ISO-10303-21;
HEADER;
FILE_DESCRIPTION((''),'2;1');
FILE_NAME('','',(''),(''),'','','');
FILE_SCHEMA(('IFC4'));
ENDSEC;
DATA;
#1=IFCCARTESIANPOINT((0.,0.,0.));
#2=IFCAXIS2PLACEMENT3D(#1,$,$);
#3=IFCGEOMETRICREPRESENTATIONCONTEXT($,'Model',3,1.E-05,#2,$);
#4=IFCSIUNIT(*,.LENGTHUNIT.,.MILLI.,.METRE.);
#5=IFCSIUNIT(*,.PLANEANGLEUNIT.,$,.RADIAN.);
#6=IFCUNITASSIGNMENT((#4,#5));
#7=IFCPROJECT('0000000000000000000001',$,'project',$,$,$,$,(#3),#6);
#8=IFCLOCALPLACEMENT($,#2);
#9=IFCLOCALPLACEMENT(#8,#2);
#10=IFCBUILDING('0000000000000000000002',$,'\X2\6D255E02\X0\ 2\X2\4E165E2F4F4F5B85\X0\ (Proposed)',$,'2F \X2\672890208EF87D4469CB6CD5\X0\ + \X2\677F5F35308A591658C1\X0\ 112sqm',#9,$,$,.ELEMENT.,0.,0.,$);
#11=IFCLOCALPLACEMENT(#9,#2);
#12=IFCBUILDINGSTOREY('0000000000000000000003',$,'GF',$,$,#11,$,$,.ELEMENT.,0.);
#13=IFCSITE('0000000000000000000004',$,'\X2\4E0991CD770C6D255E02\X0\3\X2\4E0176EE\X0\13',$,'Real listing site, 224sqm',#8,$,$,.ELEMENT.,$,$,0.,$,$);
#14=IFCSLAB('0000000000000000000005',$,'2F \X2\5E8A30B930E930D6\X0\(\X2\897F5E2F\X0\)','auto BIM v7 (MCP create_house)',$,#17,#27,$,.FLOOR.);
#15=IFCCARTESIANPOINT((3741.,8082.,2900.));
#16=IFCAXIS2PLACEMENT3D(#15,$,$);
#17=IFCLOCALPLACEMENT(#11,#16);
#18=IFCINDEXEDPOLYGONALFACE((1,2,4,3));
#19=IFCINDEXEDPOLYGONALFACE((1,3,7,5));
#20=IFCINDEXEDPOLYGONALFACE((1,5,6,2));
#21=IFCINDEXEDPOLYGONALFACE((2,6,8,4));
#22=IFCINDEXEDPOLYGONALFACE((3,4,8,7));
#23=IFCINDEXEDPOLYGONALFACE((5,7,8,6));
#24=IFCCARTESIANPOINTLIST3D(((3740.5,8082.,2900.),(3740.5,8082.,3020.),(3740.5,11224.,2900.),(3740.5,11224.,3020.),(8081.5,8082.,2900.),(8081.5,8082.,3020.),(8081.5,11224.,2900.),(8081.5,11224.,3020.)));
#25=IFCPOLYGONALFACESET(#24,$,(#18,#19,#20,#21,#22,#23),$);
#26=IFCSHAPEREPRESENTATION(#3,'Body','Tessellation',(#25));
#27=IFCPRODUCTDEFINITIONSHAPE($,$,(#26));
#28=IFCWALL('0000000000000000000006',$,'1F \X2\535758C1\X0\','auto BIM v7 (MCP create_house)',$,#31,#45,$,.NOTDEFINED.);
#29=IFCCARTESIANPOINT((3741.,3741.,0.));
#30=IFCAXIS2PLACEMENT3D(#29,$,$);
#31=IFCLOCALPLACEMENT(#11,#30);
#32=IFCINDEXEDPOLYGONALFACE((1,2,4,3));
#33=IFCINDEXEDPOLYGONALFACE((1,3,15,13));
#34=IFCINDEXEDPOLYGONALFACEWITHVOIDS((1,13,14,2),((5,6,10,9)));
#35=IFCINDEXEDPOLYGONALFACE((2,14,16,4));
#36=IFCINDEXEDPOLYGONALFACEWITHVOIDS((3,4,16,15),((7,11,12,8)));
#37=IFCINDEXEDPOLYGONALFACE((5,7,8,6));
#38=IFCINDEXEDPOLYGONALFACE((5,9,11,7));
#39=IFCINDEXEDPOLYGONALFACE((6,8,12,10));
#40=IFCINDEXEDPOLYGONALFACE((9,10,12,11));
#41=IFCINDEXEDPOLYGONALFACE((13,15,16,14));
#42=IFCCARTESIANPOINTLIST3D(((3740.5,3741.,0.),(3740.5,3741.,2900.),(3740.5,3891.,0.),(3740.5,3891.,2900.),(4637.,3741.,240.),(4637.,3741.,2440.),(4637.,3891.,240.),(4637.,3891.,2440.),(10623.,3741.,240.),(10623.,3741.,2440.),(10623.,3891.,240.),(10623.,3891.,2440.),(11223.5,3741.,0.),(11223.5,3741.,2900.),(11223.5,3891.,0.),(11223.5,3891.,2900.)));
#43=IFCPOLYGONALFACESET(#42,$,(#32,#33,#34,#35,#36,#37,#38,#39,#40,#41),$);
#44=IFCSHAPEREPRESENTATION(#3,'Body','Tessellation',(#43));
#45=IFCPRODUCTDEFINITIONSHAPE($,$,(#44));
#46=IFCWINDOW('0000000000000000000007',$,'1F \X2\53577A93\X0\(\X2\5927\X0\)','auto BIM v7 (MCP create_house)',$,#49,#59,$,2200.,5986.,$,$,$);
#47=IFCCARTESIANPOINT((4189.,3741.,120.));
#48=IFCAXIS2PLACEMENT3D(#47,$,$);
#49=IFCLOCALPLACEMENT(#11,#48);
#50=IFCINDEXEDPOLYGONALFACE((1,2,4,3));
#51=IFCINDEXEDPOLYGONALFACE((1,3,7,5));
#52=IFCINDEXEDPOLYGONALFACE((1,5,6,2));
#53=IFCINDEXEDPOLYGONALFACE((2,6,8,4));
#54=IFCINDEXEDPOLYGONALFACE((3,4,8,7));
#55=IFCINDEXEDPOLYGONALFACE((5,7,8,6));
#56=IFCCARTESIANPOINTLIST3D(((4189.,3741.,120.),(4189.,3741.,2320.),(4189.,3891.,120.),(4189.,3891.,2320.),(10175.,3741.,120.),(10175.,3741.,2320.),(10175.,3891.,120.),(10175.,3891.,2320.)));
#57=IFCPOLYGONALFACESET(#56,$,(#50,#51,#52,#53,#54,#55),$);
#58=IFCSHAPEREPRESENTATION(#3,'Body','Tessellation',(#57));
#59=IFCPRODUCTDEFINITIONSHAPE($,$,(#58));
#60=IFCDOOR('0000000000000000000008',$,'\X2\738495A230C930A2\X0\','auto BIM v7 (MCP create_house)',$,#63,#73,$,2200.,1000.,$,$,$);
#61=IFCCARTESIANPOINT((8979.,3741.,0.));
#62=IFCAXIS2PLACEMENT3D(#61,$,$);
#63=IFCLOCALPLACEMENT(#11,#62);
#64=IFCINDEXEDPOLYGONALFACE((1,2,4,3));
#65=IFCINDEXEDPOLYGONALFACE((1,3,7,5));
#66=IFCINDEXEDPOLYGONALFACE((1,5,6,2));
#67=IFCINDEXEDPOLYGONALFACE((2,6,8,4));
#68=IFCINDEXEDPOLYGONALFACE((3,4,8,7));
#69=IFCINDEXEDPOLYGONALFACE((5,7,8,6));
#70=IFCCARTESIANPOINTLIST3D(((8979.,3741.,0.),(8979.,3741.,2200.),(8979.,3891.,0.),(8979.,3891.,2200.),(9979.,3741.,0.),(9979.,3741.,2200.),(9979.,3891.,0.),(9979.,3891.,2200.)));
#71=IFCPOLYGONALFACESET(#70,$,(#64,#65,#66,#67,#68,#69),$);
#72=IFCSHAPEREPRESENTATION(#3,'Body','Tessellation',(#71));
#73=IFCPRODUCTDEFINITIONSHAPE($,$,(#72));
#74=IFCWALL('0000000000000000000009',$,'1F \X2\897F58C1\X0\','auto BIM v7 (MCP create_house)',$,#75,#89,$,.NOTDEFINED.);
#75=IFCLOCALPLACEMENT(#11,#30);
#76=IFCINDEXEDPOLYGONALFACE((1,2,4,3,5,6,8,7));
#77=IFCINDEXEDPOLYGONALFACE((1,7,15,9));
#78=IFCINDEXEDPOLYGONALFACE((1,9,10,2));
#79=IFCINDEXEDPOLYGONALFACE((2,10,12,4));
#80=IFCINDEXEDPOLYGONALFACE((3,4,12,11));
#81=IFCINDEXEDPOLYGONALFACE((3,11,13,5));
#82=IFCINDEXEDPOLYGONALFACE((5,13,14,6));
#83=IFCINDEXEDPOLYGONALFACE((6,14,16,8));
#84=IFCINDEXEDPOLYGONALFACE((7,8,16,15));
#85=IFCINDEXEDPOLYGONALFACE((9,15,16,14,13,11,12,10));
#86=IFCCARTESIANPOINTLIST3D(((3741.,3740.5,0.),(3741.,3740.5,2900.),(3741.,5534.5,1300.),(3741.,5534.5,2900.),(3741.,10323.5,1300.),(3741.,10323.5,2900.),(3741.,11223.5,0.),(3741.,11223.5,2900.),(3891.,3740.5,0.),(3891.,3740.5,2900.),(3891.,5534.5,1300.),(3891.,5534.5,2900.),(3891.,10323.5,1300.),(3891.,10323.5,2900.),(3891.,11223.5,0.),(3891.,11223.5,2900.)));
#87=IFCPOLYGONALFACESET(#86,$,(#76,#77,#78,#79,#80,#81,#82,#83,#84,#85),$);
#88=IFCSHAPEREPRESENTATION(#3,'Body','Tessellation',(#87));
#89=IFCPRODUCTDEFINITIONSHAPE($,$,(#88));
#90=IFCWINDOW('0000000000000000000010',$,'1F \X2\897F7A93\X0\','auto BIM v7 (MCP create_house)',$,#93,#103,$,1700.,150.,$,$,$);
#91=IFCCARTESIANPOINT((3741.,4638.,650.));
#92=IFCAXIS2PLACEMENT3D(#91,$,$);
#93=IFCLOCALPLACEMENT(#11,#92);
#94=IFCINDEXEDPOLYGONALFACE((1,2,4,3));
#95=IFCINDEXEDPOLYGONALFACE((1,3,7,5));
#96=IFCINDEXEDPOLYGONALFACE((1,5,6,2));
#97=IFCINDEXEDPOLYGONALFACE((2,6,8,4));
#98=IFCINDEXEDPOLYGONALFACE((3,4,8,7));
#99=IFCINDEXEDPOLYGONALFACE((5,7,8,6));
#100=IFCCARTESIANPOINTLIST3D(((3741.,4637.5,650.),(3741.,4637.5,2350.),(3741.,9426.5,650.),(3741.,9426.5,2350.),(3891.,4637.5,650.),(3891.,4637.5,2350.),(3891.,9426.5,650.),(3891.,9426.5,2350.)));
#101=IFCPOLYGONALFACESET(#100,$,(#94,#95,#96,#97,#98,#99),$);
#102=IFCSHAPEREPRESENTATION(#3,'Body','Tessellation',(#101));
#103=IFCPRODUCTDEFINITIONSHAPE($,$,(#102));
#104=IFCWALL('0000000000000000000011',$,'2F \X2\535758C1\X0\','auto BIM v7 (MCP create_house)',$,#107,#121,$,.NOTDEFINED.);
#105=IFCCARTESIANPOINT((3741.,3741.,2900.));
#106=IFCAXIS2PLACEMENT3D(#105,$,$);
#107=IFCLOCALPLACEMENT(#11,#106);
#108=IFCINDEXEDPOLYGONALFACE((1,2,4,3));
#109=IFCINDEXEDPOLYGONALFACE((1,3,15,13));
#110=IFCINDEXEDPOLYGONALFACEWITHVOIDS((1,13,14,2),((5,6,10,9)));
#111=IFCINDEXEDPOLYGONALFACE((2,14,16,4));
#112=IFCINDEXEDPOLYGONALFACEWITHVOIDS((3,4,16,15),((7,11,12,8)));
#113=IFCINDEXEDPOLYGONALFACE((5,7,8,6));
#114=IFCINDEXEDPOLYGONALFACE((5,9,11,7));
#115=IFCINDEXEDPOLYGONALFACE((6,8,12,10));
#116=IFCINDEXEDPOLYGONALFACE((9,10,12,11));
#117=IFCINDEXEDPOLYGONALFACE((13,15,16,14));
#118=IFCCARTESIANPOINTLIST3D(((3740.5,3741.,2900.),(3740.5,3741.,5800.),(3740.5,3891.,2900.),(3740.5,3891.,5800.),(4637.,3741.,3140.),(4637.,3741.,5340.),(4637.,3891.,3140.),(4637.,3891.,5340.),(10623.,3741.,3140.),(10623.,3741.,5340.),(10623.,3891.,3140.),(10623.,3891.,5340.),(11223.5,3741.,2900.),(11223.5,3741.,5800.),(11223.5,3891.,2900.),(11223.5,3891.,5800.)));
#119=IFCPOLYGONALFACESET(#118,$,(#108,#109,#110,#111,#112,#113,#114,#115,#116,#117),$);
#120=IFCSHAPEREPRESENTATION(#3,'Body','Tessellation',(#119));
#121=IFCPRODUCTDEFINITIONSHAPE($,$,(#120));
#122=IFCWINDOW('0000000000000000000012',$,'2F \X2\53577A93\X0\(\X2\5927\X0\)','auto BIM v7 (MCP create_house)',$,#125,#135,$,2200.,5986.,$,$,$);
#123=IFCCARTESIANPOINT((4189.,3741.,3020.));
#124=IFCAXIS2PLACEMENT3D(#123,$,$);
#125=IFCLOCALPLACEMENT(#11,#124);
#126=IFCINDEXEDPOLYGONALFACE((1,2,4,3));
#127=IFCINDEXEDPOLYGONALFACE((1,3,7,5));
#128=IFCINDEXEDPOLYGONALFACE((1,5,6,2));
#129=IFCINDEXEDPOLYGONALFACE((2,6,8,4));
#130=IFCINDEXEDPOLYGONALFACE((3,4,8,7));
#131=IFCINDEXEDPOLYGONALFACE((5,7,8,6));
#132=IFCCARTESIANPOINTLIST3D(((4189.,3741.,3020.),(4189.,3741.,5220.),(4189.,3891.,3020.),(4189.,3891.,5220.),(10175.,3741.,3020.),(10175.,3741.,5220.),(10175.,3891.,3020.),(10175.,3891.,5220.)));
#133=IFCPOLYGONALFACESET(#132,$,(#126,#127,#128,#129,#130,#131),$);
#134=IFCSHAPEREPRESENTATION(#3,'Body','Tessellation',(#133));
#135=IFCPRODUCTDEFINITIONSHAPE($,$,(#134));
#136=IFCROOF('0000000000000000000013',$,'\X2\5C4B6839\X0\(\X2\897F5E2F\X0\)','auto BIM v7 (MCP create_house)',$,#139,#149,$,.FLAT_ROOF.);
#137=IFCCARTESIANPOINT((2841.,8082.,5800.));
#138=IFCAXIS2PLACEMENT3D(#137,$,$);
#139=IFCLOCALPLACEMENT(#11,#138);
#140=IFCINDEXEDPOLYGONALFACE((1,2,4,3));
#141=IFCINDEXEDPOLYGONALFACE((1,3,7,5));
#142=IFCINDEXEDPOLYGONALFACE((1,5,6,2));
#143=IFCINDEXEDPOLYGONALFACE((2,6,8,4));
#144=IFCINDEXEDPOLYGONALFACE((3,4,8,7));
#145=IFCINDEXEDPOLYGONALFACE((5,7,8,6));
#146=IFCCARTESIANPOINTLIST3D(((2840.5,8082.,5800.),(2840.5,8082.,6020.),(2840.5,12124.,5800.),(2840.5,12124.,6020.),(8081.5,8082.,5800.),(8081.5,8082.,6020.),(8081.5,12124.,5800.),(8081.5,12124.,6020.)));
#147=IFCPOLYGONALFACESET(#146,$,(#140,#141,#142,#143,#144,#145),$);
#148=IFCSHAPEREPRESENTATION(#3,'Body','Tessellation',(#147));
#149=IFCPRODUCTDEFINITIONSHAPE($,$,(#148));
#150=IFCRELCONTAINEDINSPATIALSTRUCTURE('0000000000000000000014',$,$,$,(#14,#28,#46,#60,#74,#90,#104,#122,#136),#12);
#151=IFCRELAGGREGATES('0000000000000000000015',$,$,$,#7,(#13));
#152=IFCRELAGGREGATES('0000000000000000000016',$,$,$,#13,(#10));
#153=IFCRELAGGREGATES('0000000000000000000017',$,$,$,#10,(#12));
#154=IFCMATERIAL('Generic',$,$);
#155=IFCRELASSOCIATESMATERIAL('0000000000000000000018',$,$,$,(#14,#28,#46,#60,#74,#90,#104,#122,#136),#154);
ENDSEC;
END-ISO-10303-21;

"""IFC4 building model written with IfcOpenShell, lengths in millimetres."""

from ifc_helpers import new_model, si_unit, frame, frame_2d, origin, place, context, project, spatial, rectangle, extrude, material, element, fill, save


model = new_model("IFC4")

# Units and contexts
model_context = context("Model", 3, precision=1e-05, world=origin())
ifc_project = project(units=[si_unit("LENGTHUNIT", "METRE", prefix="MILLI"), si_unit("PLANEANGLEUNIT", "RADIAN")], contexts=[model_context])

# Site, building, storey
site_placement = place(None, origin())
site = spatial("IfcSite", under=ifc_project, at=site_placement, Name="三重県津市3丁目13", ObjectType="Real listing site, 224sqm", CompositionType="ELEMENT", RefElevation=0.0)
building_placement = place(site_placement, origin())
building = spatial("IfcBuilding", under=site, at=building_placement, Name="津市 2世帯住宅 (Proposed)", ObjectType="2F 木造軸組構法 + 板張り外壁 112sqm", CompositionType="ELEMENT", ElevationOfRefHeight=0.0, ElevationOfTerrain=0.0)
storey_placement = place(building_placement, origin())
storey = spatial("IfcBuildingStorey", under=building, at=storey_placement, Name="GF", CompositionType="ELEMENT", Elevation=0.0)

# Slab
ifc_material = material(Name="Generic")
slab_1_placement = place(storey_placement, frame((3741.0, 8082.0, 2900.0)))
element("IfcSlab", 1, at=slab_1_placement, inside=storey, material=ifc_material, Name="2F 床スラブ(西帯)", Description="auto BIM v7 (MCP create_house)", PredefinedType="FLOOR", context=model_context, shape_type="SweptSolid", body=[
    extrude(rectangle(XDim=4341.0, YDim=3142.0, at=frame_2d((2170.0, 1571.0))), frame((3741.0, 8082.0, 2900.0)), (0.0, 0.0, 1.0), 120.0),
])

# Wall, openings, window, door
wall_1_placement = place(storey_placement, frame((3741.0, 3741.0, 0.0)))
wall_1 = element("IfcWall", 2, at=wall_1_placement, inside=storey, material=ifc_material, Name="1F 南壁", Description="auto BIM v7 (MCP create_house)", PredefinedType="NOTDEFINED", context=model_context, shape_type="SweptSolid", body=[
    extrude(rectangle(XDim=7483.0, YDim=150.0, at=frame_2d((3741.0, 75.0))), frame((3741.0, 3741.0, 0.0)), (0.0, 0.0, 1.0), 2900.0),
])
opening_1_placement = place(storey_placement, frame((4189.0, 3741.0, 120.0)))
opening_1 = element("IfcOpeningElement", 3, at=opening_1_placement, cuts=wall_1, PredefinedType="NOTDEFINED", context=model_context, shape_type="SweptSolid", body=[
    extrude(rectangle(XDim=5986.0, YDim=150.0, at=frame_2d((2993.0, 75.0))), frame((4189.0, 3741.0, 120.0)), (0.0, 0.0, 1.0), 2200.0),
])
opening_2_placement = place(storey_placement, frame((8979.0, 3741.0, 0.0)))
opening_2 = element("IfcOpeningElement", 4, at=opening_2_placement, cuts=wall_1, PredefinedType="NOTDEFINED", context=model_context, shape_type="SweptSolid", body=[
    extrude(rectangle(XDim=1000.0, YDim=150.0, at=frame_2d((500.0, 75.0))), frame((8979.0, 3741.0, 0.0)), (0.0, 0.0, 1.0), 2200.0),
])
window_1_placement = place(storey_placement, frame((4189.0, 3741.0, 120.0)))
window_1 = element("IfcWindow", 5, at=window_1_placement, inside=storey, material=ifc_material, Name="1F 南窓(大)", Description="auto BIM v7 (MCP create_house)", OverallHeight=2200.0, OverallWidth=5986.0, context=model_context, shape_type="SweptSolid", body=[
    extrude(rectangle(XDim=5986.0, YDim=150.0, at=frame_2d((2993.0, 75.0))), frame((4189.0, 3741.0, 120.0)), (0.0, 0.0, 1.0), 2200.0),
])
fill(opening_1, window_1)
door_placement = place(storey_placement, frame((8979.0, 3741.0, 0.0)))
door = element("IfcDoor", 6, at=door_placement, inside=storey, material=ifc_material, Name="玄関ドア", Description="auto BIM v7 (MCP create_house)", OverallHeight=2200.0, OverallWidth=1000.0, context=model_context, shape_type="SweptSolid", body=[
    extrude(rectangle(XDim=1000.0, YDim=150.0, at=frame_2d((500.0, 75.0))), frame((8979.0, 3741.0, 0.0)), (0.0, 0.0, 1.0), 2200.0),
])
fill(opening_2, door)

# Wall, opening, window
wall_2_placement = place(storey_placement, frame((3741.0, 3741.0, 0.0)))
wall_2 = element("IfcWall", 7, at=wall_2_placement, inside=storey, material=ifc_material, Name="1F 西壁", Description="auto BIM v7 (MCP create_house)", PredefinedType="NOTDEFINED", context=model_context, shape_type="SweptSolid", body=[
    extrude(rectangle(XDim=150.0, YDim=7483.0, at=frame_2d((75.0, 3741.0))), frame((3741.0, 3741.0, 0.0)), (0.0, 0.0, 1.0), 2900.0),
])
opening_3_placement = place(storey_placement, frame((3741.0, 4638.0, 650.0)))
opening_3 = element("IfcOpeningElement", 8, at=opening_3_placement, cuts=wall_2, PredefinedType="NOTDEFINED", context=model_context, shape_type="SweptSolid", body=[
    extrude(rectangle(XDim=150.0, YDim=4789.0, at=frame_2d((75.0, 2394.0))), frame((3741.0, 4638.0, 650.0)), (0.0, 0.0, 1.0), 1700.0),
])
window_2_placement = place(storey_placement, frame((3741.0, 4638.0, 650.0)))
window_2 = element("IfcWindow", 9, at=window_2_placement, inside=storey, material=ifc_material, Name="1F 西窓", Description="auto BIM v7 (MCP create_house)", OverallHeight=1700.0, OverallWidth=150.0, context=model_context, shape_type="SweptSolid", body=[
    extrude(rectangle(XDim=150.0, YDim=4789.0, at=frame_2d((75.0, 2394.0))), frame((3741.0, 4638.0, 650.0)), (0.0, 0.0, 1.0), 1700.0),
])
fill(opening_3, window_2)

# Wall, opening, window
wall_3_placement = place(storey_placement, frame((3741.0, 3741.0, 2900.0)))
wall_3 = element("IfcWall", 10, at=wall_3_placement, inside=storey, material=ifc_material, Name="2F 南壁", Description="auto BIM v7 (MCP create_house)", PredefinedType="NOTDEFINED", context=model_context, shape_type="SweptSolid", body=[
    extrude(rectangle(XDim=7483.0, YDim=150.0, at=frame_2d((3741.0, 75.0))), frame((3741.0, 3741.0, 2900.0)), (0.0, 0.0, 1.0), 2900.0),
])
opening_4_placement = place(storey_placement, frame((4189.0, 3741.0, 3020.0)))
opening_4 = element("IfcOpeningElement", 11, at=opening_4_placement, cuts=wall_3, PredefinedType="NOTDEFINED", context=model_context, shape_type="SweptSolid", body=[
    extrude(rectangle(XDim=5986.0, YDim=150.0, at=frame_2d((2993.0, 75.0))), frame((4189.0, 3741.0, 3020.0)), (0.0, 0.0, 1.0), 2200.0),
])
window_3_placement = place(storey_placement, frame((4189.0, 3741.0, 3020.0)))
window_3 = element("IfcWindow", 12, at=window_3_placement, inside=storey, material=ifc_material, Name="2F 南窓(大)", Description="auto BIM v7 (MCP create_house)", OverallHeight=2200.0, OverallWidth=5986.0, context=model_context, shape_type="SweptSolid", body=[
    extrude(rectangle(XDim=5986.0, YDim=150.0, at=frame_2d((2993.0, 75.0))), frame((4189.0, 3741.0, 3020.0)), (0.0, 0.0, 1.0), 2200.0),
])
fill(opening_4, window_3)

# Roof
roof_1_placement = place(storey_placement, frame((2841.0, 8082.0, 5800.0)))
element("IfcRoof", 13, at=roof_1_placement, inside=storey, material=ifc_material, Name="屋根(西帯)", Description="auto BIM v7 (MCP create_house)", PredefinedType="FLAT_ROOF", context=model_context, shape_type="SweptSolid", body=[
    extrude(rectangle(XDim=5241.0, YDim=4042.0, at=frame_2d((2620.0, 2021.0))), frame((2841.0, 8082.0, 5800.0)), (0.0, 0.0, 1.0), 220.0),
])

save(model, "model.ifc")
